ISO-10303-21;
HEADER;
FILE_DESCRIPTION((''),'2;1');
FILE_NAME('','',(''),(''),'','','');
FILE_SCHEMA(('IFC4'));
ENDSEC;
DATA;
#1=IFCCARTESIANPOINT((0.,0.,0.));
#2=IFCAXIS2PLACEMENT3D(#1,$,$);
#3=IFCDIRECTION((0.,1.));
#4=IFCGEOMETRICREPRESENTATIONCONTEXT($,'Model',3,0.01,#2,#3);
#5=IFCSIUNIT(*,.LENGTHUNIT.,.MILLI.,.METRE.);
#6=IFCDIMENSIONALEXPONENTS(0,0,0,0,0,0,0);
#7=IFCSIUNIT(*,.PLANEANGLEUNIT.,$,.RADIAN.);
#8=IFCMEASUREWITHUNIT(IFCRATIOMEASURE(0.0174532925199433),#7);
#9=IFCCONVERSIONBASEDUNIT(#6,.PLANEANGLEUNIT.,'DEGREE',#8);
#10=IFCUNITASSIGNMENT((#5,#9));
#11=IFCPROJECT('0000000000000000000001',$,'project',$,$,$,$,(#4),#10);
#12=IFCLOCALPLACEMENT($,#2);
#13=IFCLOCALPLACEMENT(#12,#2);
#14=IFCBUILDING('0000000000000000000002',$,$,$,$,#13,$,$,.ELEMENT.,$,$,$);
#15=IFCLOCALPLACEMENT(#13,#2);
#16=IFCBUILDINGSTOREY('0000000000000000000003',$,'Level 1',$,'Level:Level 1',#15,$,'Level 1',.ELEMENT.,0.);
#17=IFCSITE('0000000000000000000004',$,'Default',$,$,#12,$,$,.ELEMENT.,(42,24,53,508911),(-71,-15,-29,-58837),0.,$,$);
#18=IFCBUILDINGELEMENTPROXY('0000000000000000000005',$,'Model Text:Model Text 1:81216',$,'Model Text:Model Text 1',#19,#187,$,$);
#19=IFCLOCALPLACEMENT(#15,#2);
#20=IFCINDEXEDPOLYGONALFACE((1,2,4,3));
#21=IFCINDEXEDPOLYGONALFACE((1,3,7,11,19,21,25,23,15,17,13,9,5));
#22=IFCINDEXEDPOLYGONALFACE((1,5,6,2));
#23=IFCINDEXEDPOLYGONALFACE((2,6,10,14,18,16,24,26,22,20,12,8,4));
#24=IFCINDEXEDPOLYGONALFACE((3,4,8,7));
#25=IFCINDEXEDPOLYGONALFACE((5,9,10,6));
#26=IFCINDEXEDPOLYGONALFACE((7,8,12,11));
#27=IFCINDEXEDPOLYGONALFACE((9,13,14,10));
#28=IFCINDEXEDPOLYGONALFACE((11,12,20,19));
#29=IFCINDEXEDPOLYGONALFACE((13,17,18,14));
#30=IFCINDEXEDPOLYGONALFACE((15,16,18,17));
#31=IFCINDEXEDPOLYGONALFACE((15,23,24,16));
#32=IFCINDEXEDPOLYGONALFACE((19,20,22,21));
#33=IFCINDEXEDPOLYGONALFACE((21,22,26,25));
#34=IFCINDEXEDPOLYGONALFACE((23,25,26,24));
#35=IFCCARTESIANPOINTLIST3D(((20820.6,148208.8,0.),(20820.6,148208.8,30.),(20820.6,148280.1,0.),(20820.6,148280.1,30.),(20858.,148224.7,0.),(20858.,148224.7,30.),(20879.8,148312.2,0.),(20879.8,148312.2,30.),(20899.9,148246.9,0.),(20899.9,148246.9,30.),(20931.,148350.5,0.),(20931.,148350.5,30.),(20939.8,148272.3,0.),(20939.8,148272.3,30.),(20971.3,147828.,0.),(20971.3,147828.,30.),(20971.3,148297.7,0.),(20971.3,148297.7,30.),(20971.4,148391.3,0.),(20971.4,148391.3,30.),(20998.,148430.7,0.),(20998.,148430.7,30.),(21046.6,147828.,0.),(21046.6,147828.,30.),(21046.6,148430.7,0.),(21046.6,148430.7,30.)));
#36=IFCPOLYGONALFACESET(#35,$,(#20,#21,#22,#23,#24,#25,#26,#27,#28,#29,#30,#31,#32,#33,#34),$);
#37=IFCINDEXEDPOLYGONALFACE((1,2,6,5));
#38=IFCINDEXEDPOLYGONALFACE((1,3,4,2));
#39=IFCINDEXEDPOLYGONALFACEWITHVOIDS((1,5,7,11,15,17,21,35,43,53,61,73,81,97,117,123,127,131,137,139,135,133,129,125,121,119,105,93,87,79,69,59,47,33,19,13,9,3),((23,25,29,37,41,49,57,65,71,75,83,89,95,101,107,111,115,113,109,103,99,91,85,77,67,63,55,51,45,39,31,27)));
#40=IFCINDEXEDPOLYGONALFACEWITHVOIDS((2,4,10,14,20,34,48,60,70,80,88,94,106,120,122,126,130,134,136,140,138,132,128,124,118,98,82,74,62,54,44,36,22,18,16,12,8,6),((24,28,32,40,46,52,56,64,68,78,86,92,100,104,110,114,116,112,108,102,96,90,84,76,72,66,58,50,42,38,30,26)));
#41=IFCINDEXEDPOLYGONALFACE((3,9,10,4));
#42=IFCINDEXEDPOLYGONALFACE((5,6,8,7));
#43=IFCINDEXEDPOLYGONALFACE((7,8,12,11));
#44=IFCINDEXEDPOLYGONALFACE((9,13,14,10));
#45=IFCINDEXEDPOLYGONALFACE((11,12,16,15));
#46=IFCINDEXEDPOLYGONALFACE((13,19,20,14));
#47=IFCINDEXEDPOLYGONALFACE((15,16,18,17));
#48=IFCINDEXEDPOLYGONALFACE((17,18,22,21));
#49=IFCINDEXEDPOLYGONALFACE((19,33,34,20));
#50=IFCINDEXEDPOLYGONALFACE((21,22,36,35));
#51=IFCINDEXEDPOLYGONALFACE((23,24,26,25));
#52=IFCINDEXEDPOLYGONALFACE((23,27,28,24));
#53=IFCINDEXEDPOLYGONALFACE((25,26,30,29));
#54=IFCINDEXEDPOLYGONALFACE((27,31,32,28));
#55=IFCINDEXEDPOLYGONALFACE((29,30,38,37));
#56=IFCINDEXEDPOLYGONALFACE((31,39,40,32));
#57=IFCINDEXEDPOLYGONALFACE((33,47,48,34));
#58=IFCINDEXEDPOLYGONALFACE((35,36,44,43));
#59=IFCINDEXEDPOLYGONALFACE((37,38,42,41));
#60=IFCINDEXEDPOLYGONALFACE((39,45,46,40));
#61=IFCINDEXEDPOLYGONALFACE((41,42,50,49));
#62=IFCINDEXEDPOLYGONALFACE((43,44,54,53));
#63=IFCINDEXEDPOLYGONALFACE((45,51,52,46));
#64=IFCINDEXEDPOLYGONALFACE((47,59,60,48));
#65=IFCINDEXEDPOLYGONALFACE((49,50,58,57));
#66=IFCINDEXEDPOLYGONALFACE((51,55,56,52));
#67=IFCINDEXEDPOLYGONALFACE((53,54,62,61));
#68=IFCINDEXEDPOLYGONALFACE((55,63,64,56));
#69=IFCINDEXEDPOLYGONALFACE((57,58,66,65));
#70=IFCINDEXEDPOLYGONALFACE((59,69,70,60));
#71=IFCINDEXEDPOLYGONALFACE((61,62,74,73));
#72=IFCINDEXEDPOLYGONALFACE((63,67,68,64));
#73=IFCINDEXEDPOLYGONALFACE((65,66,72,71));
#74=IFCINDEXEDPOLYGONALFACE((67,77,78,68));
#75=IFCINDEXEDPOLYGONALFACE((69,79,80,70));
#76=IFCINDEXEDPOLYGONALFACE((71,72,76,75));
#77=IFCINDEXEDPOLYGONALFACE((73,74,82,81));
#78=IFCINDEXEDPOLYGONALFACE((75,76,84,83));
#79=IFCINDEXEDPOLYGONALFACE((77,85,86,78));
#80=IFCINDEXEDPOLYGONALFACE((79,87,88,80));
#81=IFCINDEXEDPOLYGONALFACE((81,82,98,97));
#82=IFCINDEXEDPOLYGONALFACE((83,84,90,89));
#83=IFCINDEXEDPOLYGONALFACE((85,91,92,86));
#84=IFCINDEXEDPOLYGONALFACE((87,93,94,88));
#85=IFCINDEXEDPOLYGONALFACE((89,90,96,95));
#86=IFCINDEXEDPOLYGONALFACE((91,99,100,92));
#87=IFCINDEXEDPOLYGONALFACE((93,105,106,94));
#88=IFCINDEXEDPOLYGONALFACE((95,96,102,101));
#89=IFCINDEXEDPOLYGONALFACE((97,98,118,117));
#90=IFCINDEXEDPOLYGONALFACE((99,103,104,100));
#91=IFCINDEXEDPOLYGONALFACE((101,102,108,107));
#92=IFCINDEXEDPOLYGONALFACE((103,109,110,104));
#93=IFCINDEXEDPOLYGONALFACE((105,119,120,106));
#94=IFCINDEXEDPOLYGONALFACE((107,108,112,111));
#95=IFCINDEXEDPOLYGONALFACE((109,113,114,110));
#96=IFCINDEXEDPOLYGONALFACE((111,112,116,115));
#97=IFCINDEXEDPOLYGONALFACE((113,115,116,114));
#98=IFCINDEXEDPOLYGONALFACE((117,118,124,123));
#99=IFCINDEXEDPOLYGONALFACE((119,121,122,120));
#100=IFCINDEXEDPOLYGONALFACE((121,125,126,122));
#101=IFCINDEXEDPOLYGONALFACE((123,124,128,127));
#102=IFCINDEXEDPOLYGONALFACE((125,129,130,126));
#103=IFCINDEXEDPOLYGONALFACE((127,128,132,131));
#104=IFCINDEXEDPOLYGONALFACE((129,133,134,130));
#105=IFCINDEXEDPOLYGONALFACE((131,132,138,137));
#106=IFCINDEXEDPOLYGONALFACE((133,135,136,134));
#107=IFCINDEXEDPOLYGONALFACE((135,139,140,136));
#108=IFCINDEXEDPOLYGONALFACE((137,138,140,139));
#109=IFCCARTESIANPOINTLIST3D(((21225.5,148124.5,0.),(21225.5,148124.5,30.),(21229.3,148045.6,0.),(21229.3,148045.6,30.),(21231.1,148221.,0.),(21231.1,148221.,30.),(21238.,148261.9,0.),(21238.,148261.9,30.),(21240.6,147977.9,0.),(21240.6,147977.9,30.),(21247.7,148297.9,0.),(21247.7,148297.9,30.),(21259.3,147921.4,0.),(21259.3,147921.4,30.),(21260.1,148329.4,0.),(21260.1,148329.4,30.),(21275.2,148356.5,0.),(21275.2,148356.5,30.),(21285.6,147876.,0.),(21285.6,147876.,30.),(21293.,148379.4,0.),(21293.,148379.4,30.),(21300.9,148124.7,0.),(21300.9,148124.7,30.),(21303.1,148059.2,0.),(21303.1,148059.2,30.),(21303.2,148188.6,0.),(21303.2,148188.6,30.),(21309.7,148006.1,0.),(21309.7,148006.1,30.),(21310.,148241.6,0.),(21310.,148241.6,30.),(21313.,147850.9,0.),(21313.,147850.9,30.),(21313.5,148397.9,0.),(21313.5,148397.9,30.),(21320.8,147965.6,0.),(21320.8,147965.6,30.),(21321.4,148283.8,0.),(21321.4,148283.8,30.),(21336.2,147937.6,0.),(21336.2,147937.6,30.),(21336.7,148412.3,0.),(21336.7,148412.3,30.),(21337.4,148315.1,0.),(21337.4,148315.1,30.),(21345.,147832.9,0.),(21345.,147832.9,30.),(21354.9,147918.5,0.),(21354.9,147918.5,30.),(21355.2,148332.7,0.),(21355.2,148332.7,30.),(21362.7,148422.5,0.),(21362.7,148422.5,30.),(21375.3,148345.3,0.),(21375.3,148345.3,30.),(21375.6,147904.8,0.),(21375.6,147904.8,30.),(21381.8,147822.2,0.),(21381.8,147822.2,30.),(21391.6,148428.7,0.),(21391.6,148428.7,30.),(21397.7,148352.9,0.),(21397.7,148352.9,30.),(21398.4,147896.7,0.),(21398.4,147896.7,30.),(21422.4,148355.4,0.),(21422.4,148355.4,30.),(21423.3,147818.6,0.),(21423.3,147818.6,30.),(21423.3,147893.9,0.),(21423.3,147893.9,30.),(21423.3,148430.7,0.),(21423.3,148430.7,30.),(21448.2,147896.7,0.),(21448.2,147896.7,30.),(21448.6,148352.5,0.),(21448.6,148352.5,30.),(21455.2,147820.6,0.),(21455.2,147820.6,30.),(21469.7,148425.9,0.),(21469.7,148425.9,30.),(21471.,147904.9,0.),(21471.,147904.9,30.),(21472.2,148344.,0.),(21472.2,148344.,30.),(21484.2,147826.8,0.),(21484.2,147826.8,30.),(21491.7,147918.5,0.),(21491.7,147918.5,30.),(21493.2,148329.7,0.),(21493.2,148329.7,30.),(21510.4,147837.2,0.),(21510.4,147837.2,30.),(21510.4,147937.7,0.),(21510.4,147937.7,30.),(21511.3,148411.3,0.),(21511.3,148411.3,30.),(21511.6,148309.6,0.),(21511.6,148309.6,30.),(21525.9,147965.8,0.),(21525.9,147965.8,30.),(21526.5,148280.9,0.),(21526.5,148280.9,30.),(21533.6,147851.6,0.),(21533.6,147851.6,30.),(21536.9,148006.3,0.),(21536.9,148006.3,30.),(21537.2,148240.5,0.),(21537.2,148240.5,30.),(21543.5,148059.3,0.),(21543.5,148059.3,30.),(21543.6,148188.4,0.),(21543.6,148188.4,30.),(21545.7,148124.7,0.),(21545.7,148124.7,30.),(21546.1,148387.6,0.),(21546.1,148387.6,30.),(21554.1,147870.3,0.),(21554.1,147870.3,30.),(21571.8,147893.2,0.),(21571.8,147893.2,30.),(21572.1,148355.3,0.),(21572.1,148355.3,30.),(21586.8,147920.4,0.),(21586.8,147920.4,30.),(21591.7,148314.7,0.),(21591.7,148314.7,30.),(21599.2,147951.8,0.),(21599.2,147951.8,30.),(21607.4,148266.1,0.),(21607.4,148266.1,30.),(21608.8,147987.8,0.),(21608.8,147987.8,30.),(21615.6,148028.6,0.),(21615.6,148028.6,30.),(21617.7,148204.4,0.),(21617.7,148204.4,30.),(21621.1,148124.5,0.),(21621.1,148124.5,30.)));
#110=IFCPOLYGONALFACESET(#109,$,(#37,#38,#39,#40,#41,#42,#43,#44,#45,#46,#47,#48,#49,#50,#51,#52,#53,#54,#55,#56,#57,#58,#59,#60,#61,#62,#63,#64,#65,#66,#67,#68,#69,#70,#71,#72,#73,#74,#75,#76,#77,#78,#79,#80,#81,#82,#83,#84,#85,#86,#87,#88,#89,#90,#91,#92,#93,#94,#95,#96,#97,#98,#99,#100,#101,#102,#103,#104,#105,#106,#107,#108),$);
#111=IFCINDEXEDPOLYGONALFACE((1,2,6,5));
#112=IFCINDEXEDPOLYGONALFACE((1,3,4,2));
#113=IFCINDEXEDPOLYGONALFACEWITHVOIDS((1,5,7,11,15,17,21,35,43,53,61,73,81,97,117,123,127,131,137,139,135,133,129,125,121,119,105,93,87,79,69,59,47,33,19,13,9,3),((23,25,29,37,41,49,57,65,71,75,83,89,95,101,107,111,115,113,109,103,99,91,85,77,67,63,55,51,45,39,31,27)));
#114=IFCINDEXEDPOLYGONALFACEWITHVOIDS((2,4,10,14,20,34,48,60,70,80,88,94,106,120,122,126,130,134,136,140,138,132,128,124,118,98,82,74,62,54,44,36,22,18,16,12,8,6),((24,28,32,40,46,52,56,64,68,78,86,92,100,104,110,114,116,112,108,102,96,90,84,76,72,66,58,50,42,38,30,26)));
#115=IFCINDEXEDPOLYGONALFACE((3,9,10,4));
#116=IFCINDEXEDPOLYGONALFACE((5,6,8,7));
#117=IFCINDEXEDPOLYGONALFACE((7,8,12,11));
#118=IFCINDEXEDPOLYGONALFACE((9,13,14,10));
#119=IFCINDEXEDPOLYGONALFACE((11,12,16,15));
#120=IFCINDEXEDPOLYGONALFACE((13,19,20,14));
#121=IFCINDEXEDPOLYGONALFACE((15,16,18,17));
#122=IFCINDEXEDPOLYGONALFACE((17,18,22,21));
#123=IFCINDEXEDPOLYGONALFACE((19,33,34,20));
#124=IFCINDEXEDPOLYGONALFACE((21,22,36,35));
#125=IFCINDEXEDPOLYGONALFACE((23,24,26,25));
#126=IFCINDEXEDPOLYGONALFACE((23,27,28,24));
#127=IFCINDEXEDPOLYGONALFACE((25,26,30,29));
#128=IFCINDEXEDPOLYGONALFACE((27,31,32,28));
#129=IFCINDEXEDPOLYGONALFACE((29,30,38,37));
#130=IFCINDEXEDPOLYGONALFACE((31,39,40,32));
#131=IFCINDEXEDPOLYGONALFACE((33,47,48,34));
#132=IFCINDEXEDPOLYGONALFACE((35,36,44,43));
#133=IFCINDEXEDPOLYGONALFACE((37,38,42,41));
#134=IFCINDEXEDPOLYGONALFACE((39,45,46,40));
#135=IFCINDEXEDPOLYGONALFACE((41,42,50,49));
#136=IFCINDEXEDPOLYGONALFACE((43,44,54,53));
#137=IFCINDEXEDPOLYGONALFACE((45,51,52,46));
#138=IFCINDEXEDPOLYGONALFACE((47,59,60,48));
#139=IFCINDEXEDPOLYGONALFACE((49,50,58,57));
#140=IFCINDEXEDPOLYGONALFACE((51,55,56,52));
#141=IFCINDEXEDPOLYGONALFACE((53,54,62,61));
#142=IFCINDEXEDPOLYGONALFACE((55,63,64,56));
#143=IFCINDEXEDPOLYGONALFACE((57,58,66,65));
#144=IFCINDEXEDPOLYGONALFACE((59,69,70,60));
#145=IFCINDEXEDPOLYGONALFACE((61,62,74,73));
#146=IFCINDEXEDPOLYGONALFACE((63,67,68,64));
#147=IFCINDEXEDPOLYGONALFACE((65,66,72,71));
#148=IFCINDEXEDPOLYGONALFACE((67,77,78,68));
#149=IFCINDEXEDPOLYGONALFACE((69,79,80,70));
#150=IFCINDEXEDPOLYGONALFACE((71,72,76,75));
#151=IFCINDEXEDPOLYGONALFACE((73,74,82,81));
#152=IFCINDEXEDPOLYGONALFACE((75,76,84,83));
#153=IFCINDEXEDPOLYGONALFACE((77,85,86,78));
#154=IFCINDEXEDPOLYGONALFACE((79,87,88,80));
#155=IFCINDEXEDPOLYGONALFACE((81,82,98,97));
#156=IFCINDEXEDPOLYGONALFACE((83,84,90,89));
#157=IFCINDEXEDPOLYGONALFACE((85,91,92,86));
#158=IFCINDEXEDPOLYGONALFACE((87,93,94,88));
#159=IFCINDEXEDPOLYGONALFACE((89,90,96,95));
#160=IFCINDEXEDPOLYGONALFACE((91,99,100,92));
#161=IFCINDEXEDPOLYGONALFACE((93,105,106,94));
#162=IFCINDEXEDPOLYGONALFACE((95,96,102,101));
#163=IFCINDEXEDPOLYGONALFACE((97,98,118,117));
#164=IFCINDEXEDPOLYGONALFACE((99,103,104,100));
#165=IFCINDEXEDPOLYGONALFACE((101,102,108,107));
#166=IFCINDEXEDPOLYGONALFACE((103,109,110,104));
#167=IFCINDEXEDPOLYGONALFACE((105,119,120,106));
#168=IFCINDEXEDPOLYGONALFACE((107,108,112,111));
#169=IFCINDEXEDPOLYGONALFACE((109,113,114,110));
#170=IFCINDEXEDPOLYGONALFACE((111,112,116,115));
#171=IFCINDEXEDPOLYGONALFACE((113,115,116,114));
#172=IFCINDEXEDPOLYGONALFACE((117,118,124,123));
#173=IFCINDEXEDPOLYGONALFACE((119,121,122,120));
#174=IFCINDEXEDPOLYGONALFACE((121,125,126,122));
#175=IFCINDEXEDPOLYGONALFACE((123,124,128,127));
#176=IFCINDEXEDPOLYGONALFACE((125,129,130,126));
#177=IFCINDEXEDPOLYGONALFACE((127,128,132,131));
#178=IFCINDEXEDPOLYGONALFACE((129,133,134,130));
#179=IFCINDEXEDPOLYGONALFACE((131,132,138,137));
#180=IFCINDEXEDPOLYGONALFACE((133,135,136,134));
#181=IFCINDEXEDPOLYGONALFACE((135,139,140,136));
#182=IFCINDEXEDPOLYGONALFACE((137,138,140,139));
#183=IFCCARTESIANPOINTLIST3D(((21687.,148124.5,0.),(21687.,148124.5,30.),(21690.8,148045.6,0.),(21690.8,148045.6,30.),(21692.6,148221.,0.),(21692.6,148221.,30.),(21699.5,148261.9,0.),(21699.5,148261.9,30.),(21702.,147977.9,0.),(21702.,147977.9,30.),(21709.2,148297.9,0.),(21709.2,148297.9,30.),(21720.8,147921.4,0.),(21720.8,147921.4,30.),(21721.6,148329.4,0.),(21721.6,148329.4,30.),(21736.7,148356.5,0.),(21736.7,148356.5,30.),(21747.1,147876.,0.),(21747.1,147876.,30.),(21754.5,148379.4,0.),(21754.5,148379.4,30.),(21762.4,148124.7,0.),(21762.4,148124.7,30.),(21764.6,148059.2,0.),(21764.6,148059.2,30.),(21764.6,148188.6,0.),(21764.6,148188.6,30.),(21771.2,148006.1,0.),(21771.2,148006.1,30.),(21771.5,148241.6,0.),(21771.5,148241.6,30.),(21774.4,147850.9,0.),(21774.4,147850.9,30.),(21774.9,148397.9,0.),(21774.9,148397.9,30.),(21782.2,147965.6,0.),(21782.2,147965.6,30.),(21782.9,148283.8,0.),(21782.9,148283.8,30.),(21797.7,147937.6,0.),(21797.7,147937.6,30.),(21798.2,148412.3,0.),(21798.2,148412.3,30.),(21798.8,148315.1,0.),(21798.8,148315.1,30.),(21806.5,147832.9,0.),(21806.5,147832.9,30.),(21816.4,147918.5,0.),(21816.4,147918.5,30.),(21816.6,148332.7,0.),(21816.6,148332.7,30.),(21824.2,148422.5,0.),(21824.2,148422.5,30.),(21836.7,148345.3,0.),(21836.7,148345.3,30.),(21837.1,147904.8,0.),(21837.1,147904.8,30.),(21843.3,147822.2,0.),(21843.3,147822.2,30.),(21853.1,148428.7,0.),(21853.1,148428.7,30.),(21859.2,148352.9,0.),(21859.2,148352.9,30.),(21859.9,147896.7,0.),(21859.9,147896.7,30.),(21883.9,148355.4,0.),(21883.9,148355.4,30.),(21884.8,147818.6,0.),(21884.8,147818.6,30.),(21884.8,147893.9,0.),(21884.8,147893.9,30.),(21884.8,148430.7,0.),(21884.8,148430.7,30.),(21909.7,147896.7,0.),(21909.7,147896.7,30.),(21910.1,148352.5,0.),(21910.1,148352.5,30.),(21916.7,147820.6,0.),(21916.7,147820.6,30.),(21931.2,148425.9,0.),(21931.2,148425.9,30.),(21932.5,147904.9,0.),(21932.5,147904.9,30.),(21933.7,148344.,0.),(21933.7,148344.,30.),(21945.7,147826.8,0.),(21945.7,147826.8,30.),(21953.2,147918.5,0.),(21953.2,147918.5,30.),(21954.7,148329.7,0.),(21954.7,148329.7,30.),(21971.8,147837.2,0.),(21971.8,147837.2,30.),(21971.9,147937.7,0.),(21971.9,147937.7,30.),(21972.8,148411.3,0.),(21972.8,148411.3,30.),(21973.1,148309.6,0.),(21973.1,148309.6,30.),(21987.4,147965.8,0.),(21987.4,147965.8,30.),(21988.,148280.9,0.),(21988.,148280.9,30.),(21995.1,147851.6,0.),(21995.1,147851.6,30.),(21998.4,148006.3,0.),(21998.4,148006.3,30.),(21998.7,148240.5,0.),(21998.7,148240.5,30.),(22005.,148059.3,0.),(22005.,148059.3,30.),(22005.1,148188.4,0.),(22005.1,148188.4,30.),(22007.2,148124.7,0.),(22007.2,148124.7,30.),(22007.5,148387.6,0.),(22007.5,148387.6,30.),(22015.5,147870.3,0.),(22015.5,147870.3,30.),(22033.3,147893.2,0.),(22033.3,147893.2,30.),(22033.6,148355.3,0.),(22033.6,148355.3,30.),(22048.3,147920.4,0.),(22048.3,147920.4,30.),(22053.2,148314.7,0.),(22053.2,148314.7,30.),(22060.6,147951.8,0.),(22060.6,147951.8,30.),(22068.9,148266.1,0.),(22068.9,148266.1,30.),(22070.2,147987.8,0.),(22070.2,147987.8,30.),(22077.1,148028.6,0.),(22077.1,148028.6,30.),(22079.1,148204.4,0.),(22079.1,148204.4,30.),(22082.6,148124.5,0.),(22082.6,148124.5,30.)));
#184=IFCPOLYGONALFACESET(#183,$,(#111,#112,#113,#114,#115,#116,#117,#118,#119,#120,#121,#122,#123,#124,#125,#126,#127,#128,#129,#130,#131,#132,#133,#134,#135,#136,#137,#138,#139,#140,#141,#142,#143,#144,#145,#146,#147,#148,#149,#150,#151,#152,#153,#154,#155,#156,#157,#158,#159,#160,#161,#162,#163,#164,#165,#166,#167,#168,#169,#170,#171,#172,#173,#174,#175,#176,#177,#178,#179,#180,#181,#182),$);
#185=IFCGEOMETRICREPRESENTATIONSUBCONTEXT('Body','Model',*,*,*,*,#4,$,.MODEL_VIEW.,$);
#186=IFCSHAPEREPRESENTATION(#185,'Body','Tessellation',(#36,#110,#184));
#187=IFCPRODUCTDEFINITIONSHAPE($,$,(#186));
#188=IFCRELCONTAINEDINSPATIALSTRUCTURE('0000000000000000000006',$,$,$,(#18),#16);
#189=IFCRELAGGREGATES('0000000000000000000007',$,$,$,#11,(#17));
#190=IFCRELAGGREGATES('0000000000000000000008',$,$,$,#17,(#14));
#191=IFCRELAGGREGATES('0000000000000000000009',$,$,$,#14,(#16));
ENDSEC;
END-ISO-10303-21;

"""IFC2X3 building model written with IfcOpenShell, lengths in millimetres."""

from ifc_helpers import new_model, entity, si_unit, converted_unit, direction, frame, origin, place, context, subcontext, project, spatial, polyline, outline, extrude, element, save


model = new_model("IFC2X3")

# Units and contexts
model_context = context("Model", 3, precision=0.01, world=origin(), true_north=direction((0.0, 1.0)))
body_context = subcontext(model_context, "Body", "Model", "MODEL_VIEW")
ifc_project = project(units=[si_unit("LENGTHUNIT", "METRE", prefix="MILLI"), converted_unit("PLANEANGLEUNIT", "DEGREE", entity("IfcRatioMeasure", 0.0174532925199433), si_unit("PLANEANGLEUNIT", "RADIAN"), dimensions=[0, 0, 0, 0, 0, 0, 0])], contexts=[model_context])

# Site, building, storey
site_placement = place(None, origin())
site = spatial("IfcSite", under=ifc_project, at=site_placement, Name="Default", CompositionType="ELEMENT", RefLatitude=(42, 24, 53, 508911), RefLongitude=(-71, -15, -29, -58837), RefElevation=0.0)
building_placement = place(site_placement, origin())
building = spatial("IfcBuilding", under=site, at=building_placement, CompositionType="ELEMENT")
storey_placement = place(building_placement, origin())
storey = spatial("IfcBuildingStorey", under=building, at=storey_placement, Name="Level 1", ObjectType="Level:Level 1", LongName="Level 1", CompositionType="ELEMENT", Elevation=0.0)

# Building element proxy
proxy_1_placement = place(storey_placement, origin())
element("IfcBuildingElementProxy", 1, at=proxy_1_placement, inside=storey, Name="Model Text:Model Text 1:81216", ObjectType="Model Text:Model Text 1", context=body_context, shape_type="SweptSolid", body=[
    extrude(outline(polyline([(-410.6, -111.6), (192.1, -111.6), (192.1, -63.1), (152.7, -36.4), (111.9, 4.0), (73.6, 55.2), (41.4, 114.4), (-29.8, 114.4), (-13.9, 77.0), (8.3, 35.1), (33.7, -4.8), (59.1, -36.3), (-410.6, -36.3), (-410.6, -111.6)])), frame((20935.0, 148238.6, 0.0), z_axis=(0.0, 0.0, 1.0), x_axis=(0.0, 1.0, 0.0)), (0.0, 0.0, 1.0), 30.0),
    extrude(outline(polyline([(-10.6, -198.7), (68.3, -198.7), (136.5, -190.7), (193.9, -174.7), (240.5, -150.6), (266.9, -124.4), (286.3, -93.2), (298.8, -57.0), (304.3, -15.7), (303.8, 16.2), (299.0, 45.5), (289.9, 72.1), (276.6, 96.0), (258.9, 117.3), (236.9, 136.2), (210.4, 152.5), (179.6, 166.3), (144.1, 177.6), (103.7, 186.3), (8.2, 196.4), (-71.8, 196.7), (-134.0, 189.4), (-183.3, 176.1), (-224.7, 158.4), (-258.2, 133.9), (-283.5, 100.3), (-300.1, 59.5), (-307.1, 13.4), (-306.6, -18.4), (-301.8, -47.5), (-292.8, -74.0), (-279.6, -97.9), (-262.0, -119.2), (-240.0, -138.1), (-213.6, -154.5), (-182.8, -168.4), (-147.3, -179.8), (-106.7, -188.6), (-10.6, -198.7)]), holes=[polyline([(-7.2, -123.5), (-71.0, -118.2), (-123.6, -108.8), (-165.2, -95.4), (-195.7, -78.0), (-212.4, -59.4), (-224.1, -38.7), (-230.6, -15.9), (-231.9, 8.9), (-227.8, 35.0), (-218.1, 58.1), (-202.8, 78.4), (-182.0, 95.8), (-152.6, 109.4), (-111.7, 118.1), (-59.4, 122.0), (4.4, 121.1), (69.6, 115.8), (122.2, 106.7), (162.2, 93.7), (189.5, 77.0), (207.7, 57.4), (220.4, 36.0), (227.5, 12.8), (229.1, -12.1), (225.2, -36.8), (215.9, -59.2), (201.3, -79.3), (181.4, -97.1), (152.6, -111.2), (111.6, -120.3), (58.3, -124.4), (-7.2, -123.5)])]), frame((21424.6, 148123.3, 0.0), z_axis=(0.0, 0.0, 1.0), x_axis=(0.047515, -0.998871, 0.0)), (0.0, 0.0, 1.0), 30.0),
    extrude(outline(polyline([(-10.6, -198.7), (68.3, -198.7), (136.5, -190.7), (193.9, -174.7), (240.5, -150.6), (266.9, -124.4), (286.3, -93.2), (298.8, -57.0), (304.3, -15.7), (303.8, 16.2), (299.0, 45.5), (289.9, 72.1), (276.6, 96.0), (258.9, 117.3), (236.9, 136.2), (210.4, 152.5), (179.6, 166.3), (144.1, 177.6), (103.7, 186.3), (8.2, 196.4), (-71.8, 196.7), (-134.0, 189.4), (-183.3, 176.1), (-224.7, 158.4), (-258.2, 133.9), (-283.5, 100.3), (-300.1, 59.5), (-307.1, 13.4), (-306.6, -18.4), (-301.8, -47.5), (-292.8, -74.0), (-279.6, -97.9), (-262.0, -119.2), (-240.0, -138.1), (-213.6, -154.5), (-182.8, -168.4), (-147.3, -179.8), (-106.7, -188.6), (-10.6, -198.7)]), holes=[polyline([(-7.2, -123.5), (-71.0, -118.2), (-123.6, -108.8), (-165.2, -95.4), (-195.7, -78.0), (-212.4, -59.4), (-224.1, -38.7), (-230.6, -15.9), (-231.9, 8.9), (-227.8, 35.0), (-218.1, 58.1), (-202.8, 78.4), (-182.0, 95.8), (-152.6, 109.4), (-111.7, 118.1), (-59.4, 122.0), (4.4, 121.1), (69.6, 115.8), (122.2, 106.7), (162.2, 93.7), (189.5, 77.0), (207.7, 57.4), (220.4, 36.0), (227.5, 12.8), (229.1, -12.1), (225.2, -36.8), (215.9, -59.2), (201.3, -79.3), (181.4, -97.1), (152.6, -111.2), (111.6, -120.3), (58.3, -124.4), (-7.2, -123.5)])]), frame((21886.0, 148123.3, 0.0), z_axis=(0.0, 0.0, 1.0), x_axis=(0.047515, -0.998871, 0.0)), (0.0, 0.0, 1.0), 30.0),
])

save(model, "model.ifc")
